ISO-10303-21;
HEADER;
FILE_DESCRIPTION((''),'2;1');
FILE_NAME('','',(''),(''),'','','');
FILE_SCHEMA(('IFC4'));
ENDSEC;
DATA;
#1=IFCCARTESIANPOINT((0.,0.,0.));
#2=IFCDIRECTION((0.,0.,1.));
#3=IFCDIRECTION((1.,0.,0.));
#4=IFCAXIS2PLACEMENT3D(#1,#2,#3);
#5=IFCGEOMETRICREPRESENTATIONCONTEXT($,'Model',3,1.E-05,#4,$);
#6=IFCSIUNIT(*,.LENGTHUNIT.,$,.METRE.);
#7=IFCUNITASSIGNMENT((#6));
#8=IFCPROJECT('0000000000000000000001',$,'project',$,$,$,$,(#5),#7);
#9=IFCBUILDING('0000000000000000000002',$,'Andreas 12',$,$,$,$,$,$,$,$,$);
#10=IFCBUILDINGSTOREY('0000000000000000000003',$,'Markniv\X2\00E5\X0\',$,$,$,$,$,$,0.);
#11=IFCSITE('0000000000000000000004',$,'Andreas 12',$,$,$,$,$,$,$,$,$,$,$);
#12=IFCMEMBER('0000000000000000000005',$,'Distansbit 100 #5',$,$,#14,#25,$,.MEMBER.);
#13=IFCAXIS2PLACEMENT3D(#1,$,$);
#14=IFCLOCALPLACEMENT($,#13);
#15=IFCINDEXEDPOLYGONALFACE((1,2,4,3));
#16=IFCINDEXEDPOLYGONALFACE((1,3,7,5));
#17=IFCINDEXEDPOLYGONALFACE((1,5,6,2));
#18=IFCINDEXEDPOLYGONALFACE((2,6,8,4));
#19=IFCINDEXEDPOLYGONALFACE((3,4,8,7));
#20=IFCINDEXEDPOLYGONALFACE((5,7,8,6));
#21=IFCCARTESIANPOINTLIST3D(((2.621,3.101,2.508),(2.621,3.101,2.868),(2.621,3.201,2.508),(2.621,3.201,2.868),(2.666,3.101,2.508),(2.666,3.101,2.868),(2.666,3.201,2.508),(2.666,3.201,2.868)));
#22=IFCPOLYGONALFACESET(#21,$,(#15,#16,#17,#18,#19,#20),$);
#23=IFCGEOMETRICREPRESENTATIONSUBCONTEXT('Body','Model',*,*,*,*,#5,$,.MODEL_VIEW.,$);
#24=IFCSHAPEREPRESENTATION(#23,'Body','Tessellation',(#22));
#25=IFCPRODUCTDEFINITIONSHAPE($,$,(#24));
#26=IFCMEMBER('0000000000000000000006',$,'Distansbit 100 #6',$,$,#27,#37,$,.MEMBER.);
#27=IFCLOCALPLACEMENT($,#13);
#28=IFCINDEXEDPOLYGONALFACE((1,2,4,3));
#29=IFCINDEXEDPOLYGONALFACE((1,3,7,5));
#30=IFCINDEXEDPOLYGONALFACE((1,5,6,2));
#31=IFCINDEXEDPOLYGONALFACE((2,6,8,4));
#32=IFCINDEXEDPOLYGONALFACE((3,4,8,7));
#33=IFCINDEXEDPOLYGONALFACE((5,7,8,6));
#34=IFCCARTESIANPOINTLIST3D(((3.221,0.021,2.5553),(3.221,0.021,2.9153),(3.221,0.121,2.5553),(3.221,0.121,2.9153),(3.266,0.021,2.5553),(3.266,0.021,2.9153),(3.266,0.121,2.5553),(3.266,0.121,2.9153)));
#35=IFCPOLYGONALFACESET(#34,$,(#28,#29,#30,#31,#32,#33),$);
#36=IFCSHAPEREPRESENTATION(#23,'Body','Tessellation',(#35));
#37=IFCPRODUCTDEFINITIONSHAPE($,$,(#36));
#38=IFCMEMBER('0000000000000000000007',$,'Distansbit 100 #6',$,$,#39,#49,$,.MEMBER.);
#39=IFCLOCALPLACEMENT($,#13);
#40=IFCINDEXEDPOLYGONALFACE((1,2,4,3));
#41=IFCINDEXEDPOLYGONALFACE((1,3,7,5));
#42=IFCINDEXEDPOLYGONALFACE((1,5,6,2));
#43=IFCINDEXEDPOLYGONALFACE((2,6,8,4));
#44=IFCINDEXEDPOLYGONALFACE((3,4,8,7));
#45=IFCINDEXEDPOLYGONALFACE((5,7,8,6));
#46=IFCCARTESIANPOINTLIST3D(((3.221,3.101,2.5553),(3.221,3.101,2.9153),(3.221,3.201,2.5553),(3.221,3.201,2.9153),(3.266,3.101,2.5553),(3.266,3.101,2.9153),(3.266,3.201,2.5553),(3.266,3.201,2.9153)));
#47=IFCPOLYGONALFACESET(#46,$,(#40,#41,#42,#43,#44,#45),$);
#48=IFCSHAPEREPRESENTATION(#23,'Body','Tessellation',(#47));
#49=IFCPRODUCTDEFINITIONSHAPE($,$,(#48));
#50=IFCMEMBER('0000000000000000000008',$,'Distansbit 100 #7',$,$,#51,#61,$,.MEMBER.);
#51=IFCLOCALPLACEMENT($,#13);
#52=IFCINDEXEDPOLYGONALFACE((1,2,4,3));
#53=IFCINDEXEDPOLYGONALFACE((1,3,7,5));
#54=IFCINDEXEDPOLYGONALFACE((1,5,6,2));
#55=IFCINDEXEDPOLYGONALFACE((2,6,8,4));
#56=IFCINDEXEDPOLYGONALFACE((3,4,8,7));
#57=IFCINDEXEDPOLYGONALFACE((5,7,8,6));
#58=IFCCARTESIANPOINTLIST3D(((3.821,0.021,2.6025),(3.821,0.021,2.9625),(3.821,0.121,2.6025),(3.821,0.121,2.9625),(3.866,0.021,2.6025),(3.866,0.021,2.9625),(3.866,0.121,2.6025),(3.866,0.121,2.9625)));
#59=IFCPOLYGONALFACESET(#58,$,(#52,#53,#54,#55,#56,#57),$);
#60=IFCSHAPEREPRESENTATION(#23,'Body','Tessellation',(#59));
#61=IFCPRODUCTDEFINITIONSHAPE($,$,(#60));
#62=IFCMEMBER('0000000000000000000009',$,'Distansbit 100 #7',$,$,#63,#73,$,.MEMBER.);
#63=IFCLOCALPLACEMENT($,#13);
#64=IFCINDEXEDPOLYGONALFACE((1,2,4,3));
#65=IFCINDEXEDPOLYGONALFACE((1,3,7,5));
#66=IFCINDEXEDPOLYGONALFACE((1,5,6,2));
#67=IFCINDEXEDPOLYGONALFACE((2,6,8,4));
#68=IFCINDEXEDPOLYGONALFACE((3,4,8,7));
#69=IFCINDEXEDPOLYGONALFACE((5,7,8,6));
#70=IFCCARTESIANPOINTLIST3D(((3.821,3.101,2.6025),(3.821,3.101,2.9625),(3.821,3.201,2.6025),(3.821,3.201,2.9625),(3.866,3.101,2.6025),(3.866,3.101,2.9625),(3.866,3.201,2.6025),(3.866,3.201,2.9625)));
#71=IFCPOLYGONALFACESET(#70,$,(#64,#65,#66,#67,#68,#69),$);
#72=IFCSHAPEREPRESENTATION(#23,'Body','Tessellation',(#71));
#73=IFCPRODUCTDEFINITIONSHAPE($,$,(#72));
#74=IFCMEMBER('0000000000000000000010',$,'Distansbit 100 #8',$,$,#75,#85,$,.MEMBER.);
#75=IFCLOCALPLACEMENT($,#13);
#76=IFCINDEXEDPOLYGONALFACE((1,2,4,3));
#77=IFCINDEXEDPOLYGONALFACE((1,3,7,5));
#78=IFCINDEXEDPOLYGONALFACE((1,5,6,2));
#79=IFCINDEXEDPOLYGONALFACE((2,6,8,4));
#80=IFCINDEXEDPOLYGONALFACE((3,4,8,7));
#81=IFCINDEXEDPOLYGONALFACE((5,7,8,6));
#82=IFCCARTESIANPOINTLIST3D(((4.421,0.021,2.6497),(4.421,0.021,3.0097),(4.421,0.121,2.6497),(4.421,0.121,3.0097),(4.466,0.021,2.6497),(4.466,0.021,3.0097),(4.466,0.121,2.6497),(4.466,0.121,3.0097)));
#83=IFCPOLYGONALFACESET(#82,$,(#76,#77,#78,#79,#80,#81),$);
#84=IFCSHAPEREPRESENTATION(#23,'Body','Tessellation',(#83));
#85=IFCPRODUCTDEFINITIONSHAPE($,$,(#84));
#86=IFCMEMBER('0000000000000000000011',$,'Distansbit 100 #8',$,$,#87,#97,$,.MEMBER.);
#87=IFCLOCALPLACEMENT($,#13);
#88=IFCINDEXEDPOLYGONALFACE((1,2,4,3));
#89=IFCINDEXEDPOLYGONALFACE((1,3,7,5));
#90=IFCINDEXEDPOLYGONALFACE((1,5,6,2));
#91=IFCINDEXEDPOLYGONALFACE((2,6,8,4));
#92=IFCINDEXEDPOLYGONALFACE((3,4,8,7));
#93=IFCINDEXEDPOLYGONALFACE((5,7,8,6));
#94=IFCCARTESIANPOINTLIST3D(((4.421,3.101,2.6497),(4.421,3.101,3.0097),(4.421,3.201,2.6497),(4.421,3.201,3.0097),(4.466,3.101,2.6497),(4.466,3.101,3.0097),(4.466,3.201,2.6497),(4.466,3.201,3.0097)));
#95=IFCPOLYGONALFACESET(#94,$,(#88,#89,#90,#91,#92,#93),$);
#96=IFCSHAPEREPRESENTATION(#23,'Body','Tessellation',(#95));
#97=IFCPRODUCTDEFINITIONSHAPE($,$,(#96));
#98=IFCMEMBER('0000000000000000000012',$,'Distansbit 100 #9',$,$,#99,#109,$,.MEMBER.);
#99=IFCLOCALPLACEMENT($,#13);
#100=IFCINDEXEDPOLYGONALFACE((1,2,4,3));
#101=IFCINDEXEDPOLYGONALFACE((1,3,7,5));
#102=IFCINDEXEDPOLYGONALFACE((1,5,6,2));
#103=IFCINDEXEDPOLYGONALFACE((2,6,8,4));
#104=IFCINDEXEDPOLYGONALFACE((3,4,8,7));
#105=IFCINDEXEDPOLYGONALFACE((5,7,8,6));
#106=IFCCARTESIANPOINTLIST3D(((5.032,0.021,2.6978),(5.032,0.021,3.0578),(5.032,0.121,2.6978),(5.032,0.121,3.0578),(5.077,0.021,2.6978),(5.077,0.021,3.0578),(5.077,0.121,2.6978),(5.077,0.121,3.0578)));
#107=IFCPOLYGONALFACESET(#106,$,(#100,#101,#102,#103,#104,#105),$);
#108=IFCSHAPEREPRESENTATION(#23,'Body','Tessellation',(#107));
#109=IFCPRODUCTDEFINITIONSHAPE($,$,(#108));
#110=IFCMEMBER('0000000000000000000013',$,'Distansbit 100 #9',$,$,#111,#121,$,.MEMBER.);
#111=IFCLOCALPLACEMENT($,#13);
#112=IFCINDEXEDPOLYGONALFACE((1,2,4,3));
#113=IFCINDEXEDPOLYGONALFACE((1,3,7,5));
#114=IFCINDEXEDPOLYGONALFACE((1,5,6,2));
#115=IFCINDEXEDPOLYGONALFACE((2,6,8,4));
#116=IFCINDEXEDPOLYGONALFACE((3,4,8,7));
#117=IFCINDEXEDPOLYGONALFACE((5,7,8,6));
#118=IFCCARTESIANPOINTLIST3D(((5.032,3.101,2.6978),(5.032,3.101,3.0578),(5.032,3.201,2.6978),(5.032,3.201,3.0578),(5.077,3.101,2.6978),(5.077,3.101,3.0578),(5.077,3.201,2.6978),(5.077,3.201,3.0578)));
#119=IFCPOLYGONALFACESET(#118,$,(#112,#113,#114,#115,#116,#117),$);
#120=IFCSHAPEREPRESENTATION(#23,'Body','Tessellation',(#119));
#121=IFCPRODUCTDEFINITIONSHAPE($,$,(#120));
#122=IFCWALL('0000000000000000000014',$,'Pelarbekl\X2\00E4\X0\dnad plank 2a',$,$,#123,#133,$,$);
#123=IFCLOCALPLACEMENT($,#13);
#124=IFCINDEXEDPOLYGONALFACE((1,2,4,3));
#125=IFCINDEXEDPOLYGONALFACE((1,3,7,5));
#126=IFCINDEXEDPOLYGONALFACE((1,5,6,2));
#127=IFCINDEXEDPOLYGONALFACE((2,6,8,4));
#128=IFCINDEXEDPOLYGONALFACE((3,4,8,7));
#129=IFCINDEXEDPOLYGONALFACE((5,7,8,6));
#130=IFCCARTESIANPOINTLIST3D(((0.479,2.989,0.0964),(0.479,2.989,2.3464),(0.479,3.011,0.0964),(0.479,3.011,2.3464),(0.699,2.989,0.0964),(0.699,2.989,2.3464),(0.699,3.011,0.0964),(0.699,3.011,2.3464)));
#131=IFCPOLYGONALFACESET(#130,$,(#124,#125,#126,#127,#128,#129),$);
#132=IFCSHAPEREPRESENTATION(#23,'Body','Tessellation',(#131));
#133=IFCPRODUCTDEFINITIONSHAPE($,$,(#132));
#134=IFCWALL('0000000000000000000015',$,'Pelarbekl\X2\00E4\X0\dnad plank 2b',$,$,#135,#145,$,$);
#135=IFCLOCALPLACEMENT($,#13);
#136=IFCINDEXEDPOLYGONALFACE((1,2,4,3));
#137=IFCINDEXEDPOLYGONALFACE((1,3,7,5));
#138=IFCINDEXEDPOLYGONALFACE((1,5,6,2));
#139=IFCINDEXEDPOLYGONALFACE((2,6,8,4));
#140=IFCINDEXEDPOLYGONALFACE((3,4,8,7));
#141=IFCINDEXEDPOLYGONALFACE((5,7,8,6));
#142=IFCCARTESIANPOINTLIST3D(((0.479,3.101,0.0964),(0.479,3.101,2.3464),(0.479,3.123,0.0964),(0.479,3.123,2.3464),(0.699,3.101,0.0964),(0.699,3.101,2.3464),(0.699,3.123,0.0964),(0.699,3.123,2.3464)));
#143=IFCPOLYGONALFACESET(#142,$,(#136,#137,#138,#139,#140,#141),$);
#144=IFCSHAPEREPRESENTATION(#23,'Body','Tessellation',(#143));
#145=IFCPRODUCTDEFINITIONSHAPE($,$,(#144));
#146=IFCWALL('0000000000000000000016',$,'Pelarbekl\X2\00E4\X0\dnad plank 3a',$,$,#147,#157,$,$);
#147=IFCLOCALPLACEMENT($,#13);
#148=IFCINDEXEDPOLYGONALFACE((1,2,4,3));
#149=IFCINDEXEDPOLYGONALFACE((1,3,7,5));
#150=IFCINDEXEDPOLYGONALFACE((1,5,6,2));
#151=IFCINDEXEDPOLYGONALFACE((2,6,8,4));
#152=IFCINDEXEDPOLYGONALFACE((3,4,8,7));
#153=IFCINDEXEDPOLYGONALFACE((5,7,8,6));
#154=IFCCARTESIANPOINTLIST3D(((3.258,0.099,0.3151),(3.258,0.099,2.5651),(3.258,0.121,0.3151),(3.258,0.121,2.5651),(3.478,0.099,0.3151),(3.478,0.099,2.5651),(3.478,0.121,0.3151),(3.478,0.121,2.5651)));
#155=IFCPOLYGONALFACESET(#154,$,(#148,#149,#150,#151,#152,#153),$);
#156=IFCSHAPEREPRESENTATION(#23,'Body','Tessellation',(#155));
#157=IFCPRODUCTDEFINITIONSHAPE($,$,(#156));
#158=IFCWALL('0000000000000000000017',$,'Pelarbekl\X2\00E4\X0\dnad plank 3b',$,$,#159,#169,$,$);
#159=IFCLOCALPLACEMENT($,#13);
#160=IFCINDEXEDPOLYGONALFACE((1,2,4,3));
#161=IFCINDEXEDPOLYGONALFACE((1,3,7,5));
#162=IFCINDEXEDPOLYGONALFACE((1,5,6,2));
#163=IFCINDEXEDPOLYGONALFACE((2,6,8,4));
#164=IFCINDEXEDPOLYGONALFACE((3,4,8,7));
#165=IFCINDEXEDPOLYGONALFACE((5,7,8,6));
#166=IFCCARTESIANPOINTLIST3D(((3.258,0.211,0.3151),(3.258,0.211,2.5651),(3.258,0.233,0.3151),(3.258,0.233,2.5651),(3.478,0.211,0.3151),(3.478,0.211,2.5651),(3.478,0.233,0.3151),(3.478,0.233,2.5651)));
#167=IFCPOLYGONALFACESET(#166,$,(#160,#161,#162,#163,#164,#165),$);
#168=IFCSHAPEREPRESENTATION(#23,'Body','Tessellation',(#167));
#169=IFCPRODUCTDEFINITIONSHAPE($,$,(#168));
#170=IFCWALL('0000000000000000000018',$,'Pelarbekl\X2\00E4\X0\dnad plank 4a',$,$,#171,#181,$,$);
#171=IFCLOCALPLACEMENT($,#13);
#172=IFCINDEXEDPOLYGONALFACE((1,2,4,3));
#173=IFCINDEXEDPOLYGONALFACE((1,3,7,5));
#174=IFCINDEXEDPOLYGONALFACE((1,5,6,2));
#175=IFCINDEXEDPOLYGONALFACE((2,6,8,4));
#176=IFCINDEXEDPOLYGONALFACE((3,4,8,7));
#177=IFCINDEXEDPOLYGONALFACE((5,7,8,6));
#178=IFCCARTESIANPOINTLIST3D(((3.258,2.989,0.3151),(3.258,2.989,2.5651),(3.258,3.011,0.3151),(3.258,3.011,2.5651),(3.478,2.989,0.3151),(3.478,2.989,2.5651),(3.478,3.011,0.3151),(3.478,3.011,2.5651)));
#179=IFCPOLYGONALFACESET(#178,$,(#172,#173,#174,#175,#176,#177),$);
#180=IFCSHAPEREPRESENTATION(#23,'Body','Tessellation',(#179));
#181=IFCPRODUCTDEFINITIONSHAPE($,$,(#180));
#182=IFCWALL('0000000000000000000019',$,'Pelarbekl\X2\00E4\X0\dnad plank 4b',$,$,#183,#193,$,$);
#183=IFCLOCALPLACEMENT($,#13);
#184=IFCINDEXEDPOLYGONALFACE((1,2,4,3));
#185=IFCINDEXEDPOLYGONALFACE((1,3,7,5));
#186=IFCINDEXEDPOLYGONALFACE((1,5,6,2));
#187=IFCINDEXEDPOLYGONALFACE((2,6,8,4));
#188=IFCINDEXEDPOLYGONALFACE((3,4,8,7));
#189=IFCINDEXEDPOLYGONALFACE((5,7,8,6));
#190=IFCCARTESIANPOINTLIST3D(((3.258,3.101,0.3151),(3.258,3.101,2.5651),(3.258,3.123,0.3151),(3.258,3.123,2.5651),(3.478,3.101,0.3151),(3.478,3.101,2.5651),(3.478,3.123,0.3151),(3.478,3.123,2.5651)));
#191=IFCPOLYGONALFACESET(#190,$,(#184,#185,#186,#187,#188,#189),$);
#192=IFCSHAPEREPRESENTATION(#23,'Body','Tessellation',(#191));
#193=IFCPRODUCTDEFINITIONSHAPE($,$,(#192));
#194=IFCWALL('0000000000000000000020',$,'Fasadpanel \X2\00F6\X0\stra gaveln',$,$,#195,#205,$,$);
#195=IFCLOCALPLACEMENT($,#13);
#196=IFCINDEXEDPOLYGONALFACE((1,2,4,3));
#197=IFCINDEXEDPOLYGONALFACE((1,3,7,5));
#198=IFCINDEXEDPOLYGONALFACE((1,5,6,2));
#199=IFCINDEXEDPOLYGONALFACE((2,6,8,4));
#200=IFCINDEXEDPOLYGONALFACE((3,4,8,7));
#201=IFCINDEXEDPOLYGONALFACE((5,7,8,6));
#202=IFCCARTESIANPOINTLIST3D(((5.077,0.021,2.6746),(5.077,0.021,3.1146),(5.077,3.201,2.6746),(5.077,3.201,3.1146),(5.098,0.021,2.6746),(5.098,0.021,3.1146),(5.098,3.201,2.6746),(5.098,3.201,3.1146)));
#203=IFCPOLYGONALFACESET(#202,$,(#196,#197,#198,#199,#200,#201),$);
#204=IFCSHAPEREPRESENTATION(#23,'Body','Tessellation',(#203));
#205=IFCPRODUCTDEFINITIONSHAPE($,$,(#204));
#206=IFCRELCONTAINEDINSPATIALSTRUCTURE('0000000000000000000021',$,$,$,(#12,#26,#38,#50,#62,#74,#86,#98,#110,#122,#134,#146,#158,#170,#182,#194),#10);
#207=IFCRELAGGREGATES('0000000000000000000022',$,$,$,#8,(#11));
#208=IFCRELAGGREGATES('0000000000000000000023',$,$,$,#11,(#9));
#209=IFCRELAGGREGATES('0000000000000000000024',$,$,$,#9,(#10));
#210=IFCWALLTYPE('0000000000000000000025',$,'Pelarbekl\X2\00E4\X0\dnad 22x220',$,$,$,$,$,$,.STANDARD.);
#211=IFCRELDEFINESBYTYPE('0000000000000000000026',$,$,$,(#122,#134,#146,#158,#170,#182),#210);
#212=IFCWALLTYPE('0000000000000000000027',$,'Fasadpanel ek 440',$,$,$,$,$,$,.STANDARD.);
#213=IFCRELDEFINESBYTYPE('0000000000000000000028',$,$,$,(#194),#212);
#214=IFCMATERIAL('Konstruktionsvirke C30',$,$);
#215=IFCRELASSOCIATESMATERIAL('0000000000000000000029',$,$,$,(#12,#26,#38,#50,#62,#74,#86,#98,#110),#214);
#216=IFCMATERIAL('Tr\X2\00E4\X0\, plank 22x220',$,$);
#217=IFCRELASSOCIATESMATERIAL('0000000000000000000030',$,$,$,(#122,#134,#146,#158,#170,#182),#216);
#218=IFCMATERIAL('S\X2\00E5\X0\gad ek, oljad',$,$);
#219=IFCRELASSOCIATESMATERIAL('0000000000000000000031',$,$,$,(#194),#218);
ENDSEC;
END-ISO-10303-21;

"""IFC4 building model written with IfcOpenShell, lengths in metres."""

from ifc_helpers import new_model, si_unit, frame, frame_2d, origin, origin_with_axes, origin_2d, place, context, subcontext, project, spatial, rectangle, extrude, material, type_object, element, save


model = new_model("IFC4")

# Units and contexts
model_context = context("Model", 3, precision=1e-05, world=origin_with_axes())
body_context = subcontext(model_context, "Body", "Model", "MODEL_VIEW")
ifc_project = project(units=[si_unit("LENGTHUNIT", "METRE")], contexts=[model_context])

# Site, building, storey
site = spatial("IfcSite", under=ifc_project, Name="Andreas 12")
building = spatial("IfcBuilding", under=site, Name="Andreas 12")
storey = spatial("IfcBuildingStorey", under=building, Name="Marknivå", Elevation=0.0)

# Shared definitions
ifc_material_1 = material(Name="Konstruktionsvirke C30")

# Members
for number, where, z_axis, x_axis, name in (
    (1, (2.6435, 3.151, 2.508), (0.0, 0.0, 1.0), (1.0, 0.0, 0.0), "Distansbit 100 #5"),
    (2, (3.2435, 0.071, 2.5553), (0.0, 0.0, 1.0), (1.0, 0.0, 0.0), "Distansbit 100 #6"),
    (3, (3.2435, 3.151, 2.5553), (0.0, 0.0, 1.0), (1.0, 0.0, 0.0), "Distansbit 100 #6"),
    (4, (3.8435, 0.071, 2.6025), (0.0, 0.0, 1.0), (1.0, 0.0, 0.0), "Distansbit 100 #7"),
    (5, (3.8435, 3.151, 2.6025), (0.0, 0.0, 1.0), (1.0, 0.0, 0.0), "Distansbit 100 #7"),
    (6, (4.4435, 0.071, 2.6497), (0.0, 0.0, 1.0), (1.0, 0.0, 0.0), "Distansbit 100 #8"),
    (7, (4.4435, 3.151, 2.6497), (0.0, 0.0, 1.0), (1.0, 0.0, 0.0), "Distansbit 100 #8"),
    (8, (5.0545, 0.071, 2.6978), (0.0, 0.0, 1.0), (1.0, 0.0, 0.0), "Distansbit 100 #9"),
    (9, (5.0545, 3.151, 2.6978), (0.0, 0.0, 1.0), (1.0, 0.0, 0.0), "Distansbit 100 #9"),
):
    element("IfcMember", number, at=place(None, frame(where, z_axis=z_axis, x_axis=x_axis)), inside=storey, material=ifc_material_1, Name=name, PredefinedType="MEMBER", context=body_context, shape_type="SweptSolid", body=[
        extrude(rectangle(XDim=0.045, YDim=0.1, at=origin_2d()), origin(), (0.0, 0.0, 1.0), 0.36),
    ])

# Walls
ifc_material_2 = material(Name="Trä, plank 22x220")
wall_type_1 = type_object("IfcWallType", Name="Pelarbeklädnad 22x220", PredefinedType="STANDARD")
for number, where, z_axis, x_axis, name in (
    (10, (0.589, 3.0, 0.0964), (0.0, 0.0, 1.0), (1.0, 0.0, 0.0), "Pelarbeklädnad plank 2a"),
    (11, (0.589, 3.112, 0.0964), (0.0, 0.0, 1.0), (1.0, 0.0, 0.0), "Pelarbeklädnad plank 2b"),
    (12, (3.368, 0.11, 0.3151), (0.0, 0.0, 1.0), (1.0, 0.0, 0.0), "Pelarbeklädnad plank 3a"),
    (13, (3.368, 0.222, 0.3151), (0.0, 0.0, 1.0), (1.0, 0.0, 0.0), "Pelarbeklädnad plank 3b"),
    (14, (3.368, 3.0, 0.3151), (0.0, 0.0, 1.0), (1.0, 0.0, 0.0), "Pelarbeklädnad plank 4a"),
    (15, (3.368, 3.112, 0.3151), (0.0, 0.0, 1.0), (1.0, 0.0, 0.0), "Pelarbeklädnad plank 4b"),
):
    element("IfcWall", number, at=place(None, frame(where, z_axis=z_axis, x_axis=x_axis)), inside=storey, type_object=wall_type_1, material=ifc_material_2, Name=name, context=body_context, shape_type="SweptSolid", body=[
        extrude(rectangle(XDim=0.22, YDim=0.022, at=origin_2d()), origin(), (0.0, 0.0, 1.0), 2.25),
    ])
ifc_material_3 = material(Name="Sågad ek, oljad")
wall_type_2 = type_object("IfcWallType", Name="Fasadpanel ek 440", PredefinedType="STANDARD")
wall_placement = place(None, frame((5.077, 0.021, 2.6746), z_axis=(0.0, 0.0, 1.0), x_axis=(1.0, 0.0, 0.0)))
element("IfcWall", 16, at=wall_placement, inside=storey, type_object=wall_type_2, material=ifc_material_3, Name="Fasadpanel östra gaveln", context=body_context, shape_type="SweptSolid", body=[
    extrude(rectangle(XDim=0.021, YDim=3.18, at=frame_2d((0.0105, 1.59))), origin(), (0.0, 0.0, 1.0), 0.44),
])

save(model, "model.ifc")
